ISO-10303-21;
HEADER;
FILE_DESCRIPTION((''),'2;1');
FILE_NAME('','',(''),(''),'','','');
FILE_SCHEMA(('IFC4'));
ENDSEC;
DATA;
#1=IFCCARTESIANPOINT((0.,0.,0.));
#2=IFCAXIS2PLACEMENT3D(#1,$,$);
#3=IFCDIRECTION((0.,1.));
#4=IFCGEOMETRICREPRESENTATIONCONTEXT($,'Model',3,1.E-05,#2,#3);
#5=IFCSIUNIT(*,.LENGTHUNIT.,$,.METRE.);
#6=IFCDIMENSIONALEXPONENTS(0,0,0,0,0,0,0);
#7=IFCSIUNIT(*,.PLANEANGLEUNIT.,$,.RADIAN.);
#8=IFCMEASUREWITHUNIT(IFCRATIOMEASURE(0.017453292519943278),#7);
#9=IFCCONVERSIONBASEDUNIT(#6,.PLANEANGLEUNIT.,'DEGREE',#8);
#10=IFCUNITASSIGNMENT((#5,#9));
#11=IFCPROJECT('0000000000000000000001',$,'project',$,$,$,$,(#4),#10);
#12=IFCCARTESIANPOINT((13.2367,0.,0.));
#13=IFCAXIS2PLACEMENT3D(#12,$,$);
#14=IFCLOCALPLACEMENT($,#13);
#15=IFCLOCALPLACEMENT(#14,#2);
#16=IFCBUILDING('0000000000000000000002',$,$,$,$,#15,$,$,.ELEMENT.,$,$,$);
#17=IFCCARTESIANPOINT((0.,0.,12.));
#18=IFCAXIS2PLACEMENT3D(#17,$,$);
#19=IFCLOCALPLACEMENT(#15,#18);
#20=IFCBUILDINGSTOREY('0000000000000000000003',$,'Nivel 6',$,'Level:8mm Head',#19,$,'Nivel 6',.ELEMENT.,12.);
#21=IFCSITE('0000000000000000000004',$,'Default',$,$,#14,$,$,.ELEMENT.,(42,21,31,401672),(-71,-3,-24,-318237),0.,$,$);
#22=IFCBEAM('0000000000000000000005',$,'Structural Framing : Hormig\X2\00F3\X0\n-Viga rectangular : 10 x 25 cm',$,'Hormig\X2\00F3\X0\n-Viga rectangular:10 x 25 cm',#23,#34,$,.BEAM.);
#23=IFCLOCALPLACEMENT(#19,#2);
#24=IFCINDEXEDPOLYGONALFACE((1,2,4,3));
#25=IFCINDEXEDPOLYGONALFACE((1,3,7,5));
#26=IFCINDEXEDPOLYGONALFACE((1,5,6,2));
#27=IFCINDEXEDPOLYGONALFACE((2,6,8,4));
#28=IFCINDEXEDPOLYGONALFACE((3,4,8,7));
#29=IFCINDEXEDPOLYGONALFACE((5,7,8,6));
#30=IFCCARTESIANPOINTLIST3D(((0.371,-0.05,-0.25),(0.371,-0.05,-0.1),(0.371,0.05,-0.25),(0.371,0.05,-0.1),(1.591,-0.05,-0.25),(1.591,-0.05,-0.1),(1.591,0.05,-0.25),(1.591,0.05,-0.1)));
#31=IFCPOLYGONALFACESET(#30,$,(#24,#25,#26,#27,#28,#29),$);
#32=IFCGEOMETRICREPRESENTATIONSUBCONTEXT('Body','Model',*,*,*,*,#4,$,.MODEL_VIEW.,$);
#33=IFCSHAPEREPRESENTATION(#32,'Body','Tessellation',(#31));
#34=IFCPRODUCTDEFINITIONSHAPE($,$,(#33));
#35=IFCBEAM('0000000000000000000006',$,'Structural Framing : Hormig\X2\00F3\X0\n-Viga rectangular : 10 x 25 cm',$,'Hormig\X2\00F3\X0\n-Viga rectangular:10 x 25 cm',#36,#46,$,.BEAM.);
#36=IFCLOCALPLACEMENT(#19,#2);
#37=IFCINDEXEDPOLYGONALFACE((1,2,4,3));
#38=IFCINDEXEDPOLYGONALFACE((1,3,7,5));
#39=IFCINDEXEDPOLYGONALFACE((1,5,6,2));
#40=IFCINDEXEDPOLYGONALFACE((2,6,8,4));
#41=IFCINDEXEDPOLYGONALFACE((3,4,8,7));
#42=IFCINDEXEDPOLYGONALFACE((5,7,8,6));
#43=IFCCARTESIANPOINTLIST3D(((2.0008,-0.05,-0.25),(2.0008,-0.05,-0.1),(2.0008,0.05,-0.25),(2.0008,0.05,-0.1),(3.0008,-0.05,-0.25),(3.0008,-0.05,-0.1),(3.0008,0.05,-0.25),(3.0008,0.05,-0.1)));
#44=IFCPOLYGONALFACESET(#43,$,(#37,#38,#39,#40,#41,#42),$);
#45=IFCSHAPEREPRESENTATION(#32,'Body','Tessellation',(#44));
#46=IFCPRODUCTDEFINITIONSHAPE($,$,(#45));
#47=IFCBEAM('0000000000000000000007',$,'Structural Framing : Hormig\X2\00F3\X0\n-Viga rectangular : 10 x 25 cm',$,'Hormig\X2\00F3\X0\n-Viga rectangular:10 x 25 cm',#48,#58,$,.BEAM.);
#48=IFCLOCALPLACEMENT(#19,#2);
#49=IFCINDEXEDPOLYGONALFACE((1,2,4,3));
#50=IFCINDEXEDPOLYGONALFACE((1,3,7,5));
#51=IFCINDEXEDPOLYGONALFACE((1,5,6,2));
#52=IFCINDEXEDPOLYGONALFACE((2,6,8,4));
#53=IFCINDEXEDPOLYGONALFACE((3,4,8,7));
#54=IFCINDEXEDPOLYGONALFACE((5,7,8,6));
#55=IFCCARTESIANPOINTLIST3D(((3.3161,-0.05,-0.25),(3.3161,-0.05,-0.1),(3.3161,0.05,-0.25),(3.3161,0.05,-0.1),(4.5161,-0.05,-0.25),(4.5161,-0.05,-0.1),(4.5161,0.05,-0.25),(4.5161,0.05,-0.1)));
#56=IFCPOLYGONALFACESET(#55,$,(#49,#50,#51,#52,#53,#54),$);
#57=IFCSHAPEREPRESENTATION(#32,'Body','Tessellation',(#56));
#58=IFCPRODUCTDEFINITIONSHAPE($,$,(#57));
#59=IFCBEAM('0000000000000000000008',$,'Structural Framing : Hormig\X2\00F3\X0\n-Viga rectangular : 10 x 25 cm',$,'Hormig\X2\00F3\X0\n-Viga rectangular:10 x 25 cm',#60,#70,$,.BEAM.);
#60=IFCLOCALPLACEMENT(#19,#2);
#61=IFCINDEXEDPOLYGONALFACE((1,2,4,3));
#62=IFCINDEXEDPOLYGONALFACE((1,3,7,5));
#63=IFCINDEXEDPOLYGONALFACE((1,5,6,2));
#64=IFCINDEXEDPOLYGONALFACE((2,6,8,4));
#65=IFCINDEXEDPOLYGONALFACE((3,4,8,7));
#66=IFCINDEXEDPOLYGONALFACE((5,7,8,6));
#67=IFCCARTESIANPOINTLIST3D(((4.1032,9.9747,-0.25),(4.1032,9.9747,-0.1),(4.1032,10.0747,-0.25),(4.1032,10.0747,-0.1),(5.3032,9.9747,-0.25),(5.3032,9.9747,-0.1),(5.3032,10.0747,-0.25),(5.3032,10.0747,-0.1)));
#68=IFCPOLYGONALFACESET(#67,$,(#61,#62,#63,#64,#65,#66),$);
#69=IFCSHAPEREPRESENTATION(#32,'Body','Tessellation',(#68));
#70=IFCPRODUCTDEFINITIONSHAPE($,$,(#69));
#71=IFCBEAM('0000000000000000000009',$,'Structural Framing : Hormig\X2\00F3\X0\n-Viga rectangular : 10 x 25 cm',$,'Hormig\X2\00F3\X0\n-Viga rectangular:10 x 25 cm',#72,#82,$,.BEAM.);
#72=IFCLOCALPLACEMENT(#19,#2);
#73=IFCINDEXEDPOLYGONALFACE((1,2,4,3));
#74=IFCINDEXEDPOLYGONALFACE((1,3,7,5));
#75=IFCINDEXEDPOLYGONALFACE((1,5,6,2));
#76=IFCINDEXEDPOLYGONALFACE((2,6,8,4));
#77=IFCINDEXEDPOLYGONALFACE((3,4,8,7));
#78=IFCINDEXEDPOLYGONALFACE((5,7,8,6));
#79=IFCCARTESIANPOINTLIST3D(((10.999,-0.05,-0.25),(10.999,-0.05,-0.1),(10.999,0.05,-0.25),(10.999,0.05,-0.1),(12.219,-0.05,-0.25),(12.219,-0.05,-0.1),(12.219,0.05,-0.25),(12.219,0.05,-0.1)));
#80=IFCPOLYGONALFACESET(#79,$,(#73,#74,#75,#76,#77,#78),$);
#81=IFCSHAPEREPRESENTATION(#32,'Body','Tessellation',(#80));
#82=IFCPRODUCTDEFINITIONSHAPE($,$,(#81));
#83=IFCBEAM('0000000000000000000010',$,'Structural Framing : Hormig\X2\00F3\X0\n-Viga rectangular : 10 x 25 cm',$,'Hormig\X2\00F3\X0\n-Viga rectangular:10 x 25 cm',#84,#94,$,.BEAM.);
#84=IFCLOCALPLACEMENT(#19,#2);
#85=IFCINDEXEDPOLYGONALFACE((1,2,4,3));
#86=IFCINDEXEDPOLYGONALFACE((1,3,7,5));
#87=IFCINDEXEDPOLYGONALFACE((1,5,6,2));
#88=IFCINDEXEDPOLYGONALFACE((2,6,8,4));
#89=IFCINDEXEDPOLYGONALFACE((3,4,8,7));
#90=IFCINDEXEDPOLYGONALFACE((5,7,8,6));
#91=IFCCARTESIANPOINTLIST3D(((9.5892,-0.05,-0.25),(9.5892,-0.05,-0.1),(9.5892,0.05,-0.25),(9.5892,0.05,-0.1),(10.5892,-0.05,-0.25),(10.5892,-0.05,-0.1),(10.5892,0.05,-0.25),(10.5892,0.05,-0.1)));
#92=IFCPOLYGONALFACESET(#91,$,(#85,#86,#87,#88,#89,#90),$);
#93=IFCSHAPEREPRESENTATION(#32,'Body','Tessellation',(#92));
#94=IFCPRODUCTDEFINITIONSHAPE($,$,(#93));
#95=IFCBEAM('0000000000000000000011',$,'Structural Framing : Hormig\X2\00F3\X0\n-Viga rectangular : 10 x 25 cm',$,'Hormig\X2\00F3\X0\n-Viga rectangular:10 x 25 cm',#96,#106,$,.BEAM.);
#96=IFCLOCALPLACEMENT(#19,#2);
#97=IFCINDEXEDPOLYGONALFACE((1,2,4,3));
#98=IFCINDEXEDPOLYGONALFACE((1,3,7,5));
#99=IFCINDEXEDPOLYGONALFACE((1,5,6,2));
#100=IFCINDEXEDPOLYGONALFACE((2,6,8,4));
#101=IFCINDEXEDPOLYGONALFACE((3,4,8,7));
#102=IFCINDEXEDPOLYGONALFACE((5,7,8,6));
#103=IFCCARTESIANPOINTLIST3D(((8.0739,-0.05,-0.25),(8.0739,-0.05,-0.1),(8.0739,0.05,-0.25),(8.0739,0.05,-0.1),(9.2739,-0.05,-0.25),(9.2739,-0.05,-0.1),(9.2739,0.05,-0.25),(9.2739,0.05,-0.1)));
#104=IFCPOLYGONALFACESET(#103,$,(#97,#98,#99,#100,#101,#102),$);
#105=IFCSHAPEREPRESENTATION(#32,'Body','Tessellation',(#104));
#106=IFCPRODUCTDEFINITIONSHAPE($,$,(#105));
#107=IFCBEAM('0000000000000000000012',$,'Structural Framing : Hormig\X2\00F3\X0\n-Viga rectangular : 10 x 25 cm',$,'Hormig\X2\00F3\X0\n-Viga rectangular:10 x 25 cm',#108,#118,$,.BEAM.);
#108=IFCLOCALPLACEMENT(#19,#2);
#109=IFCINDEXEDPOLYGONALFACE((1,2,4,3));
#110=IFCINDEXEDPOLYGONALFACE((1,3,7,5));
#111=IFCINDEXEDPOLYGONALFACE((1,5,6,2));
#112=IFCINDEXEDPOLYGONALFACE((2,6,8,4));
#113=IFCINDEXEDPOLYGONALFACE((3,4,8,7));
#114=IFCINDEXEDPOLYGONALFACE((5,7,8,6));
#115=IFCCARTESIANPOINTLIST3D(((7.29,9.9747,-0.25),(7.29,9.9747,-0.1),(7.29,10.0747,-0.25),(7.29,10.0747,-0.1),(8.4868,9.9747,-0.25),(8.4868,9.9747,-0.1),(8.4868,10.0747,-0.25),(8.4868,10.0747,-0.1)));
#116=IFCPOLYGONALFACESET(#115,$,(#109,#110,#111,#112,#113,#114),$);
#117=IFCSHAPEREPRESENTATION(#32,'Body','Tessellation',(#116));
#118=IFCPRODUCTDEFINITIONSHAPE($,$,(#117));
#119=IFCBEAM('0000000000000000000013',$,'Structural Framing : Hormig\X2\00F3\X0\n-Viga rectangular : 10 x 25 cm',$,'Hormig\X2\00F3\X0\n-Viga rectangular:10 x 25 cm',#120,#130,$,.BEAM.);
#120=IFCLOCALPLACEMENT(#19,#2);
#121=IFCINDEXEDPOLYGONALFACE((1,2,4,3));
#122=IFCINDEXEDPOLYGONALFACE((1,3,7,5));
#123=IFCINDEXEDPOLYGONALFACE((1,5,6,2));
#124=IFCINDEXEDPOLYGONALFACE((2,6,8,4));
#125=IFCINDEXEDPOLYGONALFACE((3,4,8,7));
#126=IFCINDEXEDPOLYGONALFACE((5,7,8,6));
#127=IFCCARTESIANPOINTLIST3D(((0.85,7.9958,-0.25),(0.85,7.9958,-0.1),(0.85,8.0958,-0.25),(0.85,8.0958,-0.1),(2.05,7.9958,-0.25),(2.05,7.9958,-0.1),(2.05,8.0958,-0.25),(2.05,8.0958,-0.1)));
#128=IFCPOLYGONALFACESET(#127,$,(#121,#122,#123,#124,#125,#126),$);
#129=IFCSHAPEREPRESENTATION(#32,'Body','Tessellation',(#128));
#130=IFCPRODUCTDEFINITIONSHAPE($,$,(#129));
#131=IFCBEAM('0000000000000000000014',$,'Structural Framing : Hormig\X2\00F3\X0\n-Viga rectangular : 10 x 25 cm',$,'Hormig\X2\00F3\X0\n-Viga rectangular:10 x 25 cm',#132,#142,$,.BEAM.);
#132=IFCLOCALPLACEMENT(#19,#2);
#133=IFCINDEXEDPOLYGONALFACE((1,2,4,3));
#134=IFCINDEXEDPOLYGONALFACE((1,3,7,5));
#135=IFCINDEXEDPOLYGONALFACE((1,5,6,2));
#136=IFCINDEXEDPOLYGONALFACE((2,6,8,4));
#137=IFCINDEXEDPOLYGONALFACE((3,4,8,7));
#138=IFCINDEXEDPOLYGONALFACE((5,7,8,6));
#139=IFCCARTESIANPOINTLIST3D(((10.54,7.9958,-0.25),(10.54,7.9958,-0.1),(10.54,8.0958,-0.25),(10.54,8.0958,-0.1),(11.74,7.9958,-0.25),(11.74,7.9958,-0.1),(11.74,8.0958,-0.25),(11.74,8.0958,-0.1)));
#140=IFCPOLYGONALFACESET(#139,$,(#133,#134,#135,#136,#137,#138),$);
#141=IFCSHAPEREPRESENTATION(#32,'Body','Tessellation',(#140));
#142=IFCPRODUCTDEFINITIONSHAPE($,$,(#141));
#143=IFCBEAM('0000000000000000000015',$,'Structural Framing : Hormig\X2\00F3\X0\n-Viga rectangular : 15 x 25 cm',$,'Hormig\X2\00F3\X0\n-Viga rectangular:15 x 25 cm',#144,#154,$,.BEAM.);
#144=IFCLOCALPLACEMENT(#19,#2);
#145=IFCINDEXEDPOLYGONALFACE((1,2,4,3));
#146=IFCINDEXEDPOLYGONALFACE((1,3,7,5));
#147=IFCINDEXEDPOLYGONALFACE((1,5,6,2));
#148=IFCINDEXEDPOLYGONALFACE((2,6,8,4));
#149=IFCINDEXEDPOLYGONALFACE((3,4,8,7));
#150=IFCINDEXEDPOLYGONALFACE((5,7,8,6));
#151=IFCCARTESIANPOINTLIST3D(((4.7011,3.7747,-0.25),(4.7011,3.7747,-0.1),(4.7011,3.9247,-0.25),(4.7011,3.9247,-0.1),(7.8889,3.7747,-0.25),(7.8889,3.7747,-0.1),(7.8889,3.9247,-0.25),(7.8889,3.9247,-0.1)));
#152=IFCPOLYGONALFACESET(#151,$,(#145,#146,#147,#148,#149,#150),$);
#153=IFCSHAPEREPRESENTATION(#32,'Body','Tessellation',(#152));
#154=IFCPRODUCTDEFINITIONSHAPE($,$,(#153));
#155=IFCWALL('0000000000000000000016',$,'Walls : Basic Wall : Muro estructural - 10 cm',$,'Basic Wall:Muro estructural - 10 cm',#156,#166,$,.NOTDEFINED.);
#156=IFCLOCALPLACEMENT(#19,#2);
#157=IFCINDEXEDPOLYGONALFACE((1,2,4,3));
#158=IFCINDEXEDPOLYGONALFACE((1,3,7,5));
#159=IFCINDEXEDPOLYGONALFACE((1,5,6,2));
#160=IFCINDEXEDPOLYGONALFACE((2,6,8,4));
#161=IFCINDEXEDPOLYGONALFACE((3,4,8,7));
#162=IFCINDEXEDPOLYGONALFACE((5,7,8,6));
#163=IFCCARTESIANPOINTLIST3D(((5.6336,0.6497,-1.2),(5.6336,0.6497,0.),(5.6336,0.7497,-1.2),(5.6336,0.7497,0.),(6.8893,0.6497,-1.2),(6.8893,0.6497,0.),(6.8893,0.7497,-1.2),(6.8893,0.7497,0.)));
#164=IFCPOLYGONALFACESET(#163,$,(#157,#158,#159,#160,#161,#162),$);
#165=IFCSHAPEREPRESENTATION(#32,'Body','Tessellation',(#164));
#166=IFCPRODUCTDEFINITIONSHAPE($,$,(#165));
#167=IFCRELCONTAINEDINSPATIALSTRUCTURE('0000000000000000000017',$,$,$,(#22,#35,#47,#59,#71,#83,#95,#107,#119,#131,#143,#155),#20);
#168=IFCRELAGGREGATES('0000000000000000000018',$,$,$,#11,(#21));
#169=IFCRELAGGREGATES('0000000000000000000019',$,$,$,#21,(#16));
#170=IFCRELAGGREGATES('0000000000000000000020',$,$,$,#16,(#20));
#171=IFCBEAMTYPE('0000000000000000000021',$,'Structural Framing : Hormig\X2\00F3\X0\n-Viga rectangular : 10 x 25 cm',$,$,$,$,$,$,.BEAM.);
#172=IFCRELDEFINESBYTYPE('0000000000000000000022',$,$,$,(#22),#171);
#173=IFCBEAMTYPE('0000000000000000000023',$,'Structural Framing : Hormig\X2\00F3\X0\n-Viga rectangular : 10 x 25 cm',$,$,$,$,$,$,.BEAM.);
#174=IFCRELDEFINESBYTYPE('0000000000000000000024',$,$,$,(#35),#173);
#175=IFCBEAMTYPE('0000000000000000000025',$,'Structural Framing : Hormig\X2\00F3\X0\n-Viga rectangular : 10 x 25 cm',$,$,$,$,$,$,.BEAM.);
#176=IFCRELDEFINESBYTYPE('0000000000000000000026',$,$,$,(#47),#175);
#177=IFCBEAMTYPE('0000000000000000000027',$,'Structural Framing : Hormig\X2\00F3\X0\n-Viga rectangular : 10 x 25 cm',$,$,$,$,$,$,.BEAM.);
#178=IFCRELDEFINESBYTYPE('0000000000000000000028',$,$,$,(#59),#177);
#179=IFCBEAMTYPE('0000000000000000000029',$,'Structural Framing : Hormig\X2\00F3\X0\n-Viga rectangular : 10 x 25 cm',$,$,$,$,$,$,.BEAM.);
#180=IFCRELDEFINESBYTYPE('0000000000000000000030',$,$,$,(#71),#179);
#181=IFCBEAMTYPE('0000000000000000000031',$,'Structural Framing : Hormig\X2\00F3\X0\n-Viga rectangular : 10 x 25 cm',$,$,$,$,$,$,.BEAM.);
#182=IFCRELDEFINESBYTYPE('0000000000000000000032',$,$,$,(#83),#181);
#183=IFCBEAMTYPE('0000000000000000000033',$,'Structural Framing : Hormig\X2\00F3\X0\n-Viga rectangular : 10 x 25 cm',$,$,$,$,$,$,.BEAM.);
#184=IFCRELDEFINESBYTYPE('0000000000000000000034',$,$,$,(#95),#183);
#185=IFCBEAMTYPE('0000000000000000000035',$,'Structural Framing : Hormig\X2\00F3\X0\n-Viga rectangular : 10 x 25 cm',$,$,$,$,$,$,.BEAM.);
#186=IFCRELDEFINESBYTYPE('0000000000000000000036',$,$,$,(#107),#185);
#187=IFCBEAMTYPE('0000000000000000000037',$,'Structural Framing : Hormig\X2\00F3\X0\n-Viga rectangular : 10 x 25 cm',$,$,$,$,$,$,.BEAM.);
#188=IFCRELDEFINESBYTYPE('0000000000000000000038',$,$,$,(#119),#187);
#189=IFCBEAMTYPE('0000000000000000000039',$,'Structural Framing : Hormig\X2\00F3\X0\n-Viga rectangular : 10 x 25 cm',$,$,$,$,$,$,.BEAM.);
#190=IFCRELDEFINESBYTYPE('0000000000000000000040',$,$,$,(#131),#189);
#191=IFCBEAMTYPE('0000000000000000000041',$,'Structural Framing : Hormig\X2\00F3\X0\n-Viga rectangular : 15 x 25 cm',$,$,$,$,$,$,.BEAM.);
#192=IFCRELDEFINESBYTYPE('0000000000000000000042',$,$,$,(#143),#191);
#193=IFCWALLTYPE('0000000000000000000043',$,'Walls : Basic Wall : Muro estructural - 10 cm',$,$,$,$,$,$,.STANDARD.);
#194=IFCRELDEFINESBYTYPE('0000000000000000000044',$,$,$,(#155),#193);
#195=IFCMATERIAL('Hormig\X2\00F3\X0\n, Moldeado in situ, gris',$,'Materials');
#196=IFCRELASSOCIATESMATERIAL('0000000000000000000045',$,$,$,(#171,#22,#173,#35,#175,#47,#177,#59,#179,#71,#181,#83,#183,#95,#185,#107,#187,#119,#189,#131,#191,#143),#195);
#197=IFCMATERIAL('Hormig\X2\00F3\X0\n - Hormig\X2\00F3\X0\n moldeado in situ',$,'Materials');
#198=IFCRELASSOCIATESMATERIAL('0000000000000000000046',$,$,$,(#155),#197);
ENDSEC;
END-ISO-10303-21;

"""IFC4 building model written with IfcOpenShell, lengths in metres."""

from ifc_helpers import new_model, entity, si_unit, converted_unit, direction, frame, origin, place, context, subcontext, project, spatial, indexed_curve, outline, extrude, source, transform, mapped, material, type_object, type_shapes, element, save


model = new_model("IFC4")

# Units and contexts
model_context = context("Model", 3, precision=1e-05, world=origin(), true_north=direction((0.0, 1.0)))
body_context = subcontext(model_context, "Body", "Model", "MODEL_VIEW")
ifc_project = project(units=[si_unit("LENGTHUNIT", "METRE"), converted_unit("PLANEANGLEUNIT", "DEGREE", entity("IfcRatioMeasure", 0.017453292519943278), si_unit("PLANEANGLEUNIT", "RADIAN"), dimensions=[0, 0, 0, 0, 0, 0, 0])], contexts=[model_context])

# Site, building, storey
site_placement = place(None, frame((13.2367, 0.0, 0.0)))
site = spatial("IfcSite", under=ifc_project, at=site_placement, Name="Default", CompositionType="ELEMENT", RefLatitude=(42, 21, 31, 401672), RefLongitude=(-71, -3, -24, -318237), RefElevation=0.0)
building_placement = place(site_placement, origin())
building = spatial("IfcBuilding", under=site, at=building_placement, CompositionType="ELEMENT")
storey_placement = place(building_placement, frame((0.0, 0.0, 12.0)))
storey = spatial("IfcBuildingStorey", under=building, at=storey_placement, Name="Nivel 6", ObjectType="Level:8mm Head", LongName="Nivel 6", CompositionType="ELEMENT", Elevation=12.0)

# Beams
ifc_material_1 = material(Name="Hormigón, Moldeado in situ, gris", Category="Materials")
beam_type_1 = type_object("IfcBeamType", Name="Structural Framing : Hormigón-Viga rectangular : 10 x 25 cm", PredefinedType="BEAM", material=ifc_material_1)
shared_shape_1 = source(origin(), body_context, "Body", "SweptSolid", [
    extrude(outline(indexed_curve([(-0.075, -0.05), (0.075, -0.05), (0.075, 0.05), (-0.075, 0.05), (-0.075, -0.05)], self_intersect=False)), frame((0.371, 0.0, 11.825), z_axis=(1.0, 0.0, 0.0), x_axis=(0.0, 0.0, -1.0)), (0.0, 0.0, 1.0), 1.22),
])
type_shapes(beam_type_1, [shared_shape_1])
beam_1_placement = place(storey_placement, frame((0.0, 0.0, -12.0)))
element("IfcBeam", 1, at=beam_1_placement, inside=storey, type_object=beam_type_1, material=ifc_material_1, Name="Structural Framing : Hormigón-Viga rectangular : 10 x 25 cm", ObjectType="Hormigón-Viga rectangular:10 x 25 cm", PredefinedType="BEAM", context=body_context, shape_type="MappedRepresentation", body=[
    mapped(shared_shape_1, transform((0.0, 0.0, 0.0), scale=1.0)),
])
beam_type_2 = type_object("IfcBeamType", Name="Structural Framing : Hormigón-Viga rectangular : 10 x 25 cm", PredefinedType="BEAM", material=ifc_material_1)
shared_shape_2 = source(origin(), body_context, "Body", "SweptSolid", [
    extrude(outline(indexed_curve([(-0.075, -0.05), (0.075, -0.05), (0.075, 0.05), (-0.075, 0.05), (-0.075, -0.05)], self_intersect=False)), frame((2.0008, 0.0, 11.825), z_axis=(1.0, 0.0, 0.0), x_axis=(0.0, 0.0, -1.0)), (0.0, 0.0, 1.0), 1.0),
])
type_shapes(beam_type_2, [shared_shape_2])
beam_2_placement = place(storey_placement, frame((0.0, 0.0, -12.0)))
element("IfcBeam", 2, at=beam_2_placement, inside=storey, type_object=beam_type_2, material=ifc_material_1, Name="Structural Framing : Hormigón-Viga rectangular : 10 x 25 cm", ObjectType="Hormigón-Viga rectangular:10 x 25 cm", PredefinedType="BEAM", context=body_context, shape_type="MappedRepresentation", body=[
    mapped(shared_shape_2, transform((0.0, 0.0, 0.0), scale=1.0)),
])
beam_type_3 = type_object("IfcBeamType", Name="Structural Framing : Hormigón-Viga rectangular : 10 x 25 cm", PredefinedType="BEAM", material=ifc_material_1)
shared_shape_3 = source(origin(), body_context, "Body", "SweptSolid", [
    extrude(outline(indexed_curve([(-0.075, -0.05), (0.075, -0.05), (0.075, 0.05), (-0.075, 0.05), (-0.075, -0.05)], self_intersect=False)), frame((3.3161, 0.0, 11.825), z_axis=(1.0, 0.0, 0.0), x_axis=(0.0, 0.0, -1.0)), (0.0, 0.0, 1.0), 1.2),
])
type_shapes(beam_type_3, [shared_shape_3])
beam_3_placement = place(storey_placement, frame((0.0, 0.0, -12.0)))
element("IfcBeam", 3, at=beam_3_placement, inside=storey, type_object=beam_type_3, material=ifc_material_1, Name="Structural Framing : Hormigón-Viga rectangular : 10 x 25 cm", ObjectType="Hormigón-Viga rectangular:10 x 25 cm", PredefinedType="BEAM", context=body_context, shape_type="MappedRepresentation", body=[
    mapped(shared_shape_3, transform((0.0, 0.0, 0.0), scale=1.0)),
])
beam_type_4 = type_object("IfcBeamType", Name="Structural Framing : Hormigón-Viga rectangular : 10 x 25 cm", PredefinedType="BEAM", material=ifc_material_1)
shared_shape_4 = source(origin(), body_context, "Body", "SweptSolid", [
    extrude(outline(indexed_curve([(-0.075, -0.05), (0.075, -0.05), (0.075, 0.05), (-0.075, 0.05), (-0.075, -0.05)], self_intersect=False)), frame((5.3032, 10.0247, 11.825), z_axis=(-1.0, 0.0, 0.0), x_axis=(0.0, 0.0, -1.0)), (0.0, 0.0, 1.0), 1.2),
])
type_shapes(beam_type_4, [shared_shape_4])
beam_4_placement = place(storey_placement, frame((0.0, 0.0, -12.0)))
element("IfcBeam", 4, at=beam_4_placement, inside=storey, type_object=beam_type_4, material=ifc_material_1, Name="Structural Framing : Hormigón-Viga rectangular : 10 x 25 cm", ObjectType="Hormigón-Viga rectangular:10 x 25 cm", PredefinedType="BEAM", context=body_context, shape_type="MappedRepresentation", body=[
    mapped(shared_shape_4, transform((0.0, 0.0, 0.0), scale=1.0)),
])
beam_type_5 = type_object("IfcBeamType", Name="Structural Framing : Hormigón-Viga rectangular : 10 x 25 cm", PredefinedType="BEAM", material=ifc_material_1)
shared_shape_5 = source(origin(), body_context, "Body", "SweptSolid", [
    extrude(outline(indexed_curve([(-0.075, -0.05), (0.075, -0.05), (0.075, 0.05), (-0.075, 0.05), (-0.075, -0.05)], self_intersect=False)), frame((12.219, 0.0, 11.825), z_axis=(-1.0, 0.0, 0.0), x_axis=(0.0, 0.0, -1.0)), (0.0, 0.0, 1.0), 1.22),
])
type_shapes(beam_type_5, [shared_shape_5])
beam_5_placement = place(storey_placement, frame((0.0, 0.0, -12.0)))
element("IfcBeam", 5, at=beam_5_placement, inside=storey, type_object=beam_type_5, material=ifc_material_1, Name="Structural Framing : Hormigón-Viga rectangular : 10 x 25 cm", ObjectType="Hormigón-Viga rectangular:10 x 25 cm", PredefinedType="BEAM", context=body_context, shape_type="MappedRepresentation", body=[
    mapped(shared_shape_5, transform((0.0, 0.0, 0.0), scale=1.0)),
])
beam_type_6 = type_object("IfcBeamType", Name="Structural Framing : Hormigón-Viga rectangular : 10 x 25 cm", PredefinedType="BEAM", material=ifc_material_1)
shared_shape_6 = source(origin(), body_context, "Body", "SweptSolid", [
    extrude(outline(indexed_curve([(-0.075, -0.05), (0.075, -0.05), (0.075, 0.05), (-0.075, 0.05), (-0.075, -0.05)], self_intersect=False)), frame((10.5892, 0.0, 11.825), z_axis=(-1.0, 0.0, 0.0), x_axis=(0.0, 0.0, -1.0)), (0.0, 0.0, 1.0), 1.0),
])
type_shapes(beam_type_6, [shared_shape_6])
beam_6_placement = place(storey_placement, frame((0.0, 0.0, -12.0)))
element("IfcBeam", 6, at=beam_6_placement, inside=storey, type_object=beam_type_6, material=ifc_material_1, Name="Structural Framing : Hormigón-Viga rectangular : 10 x 25 cm", ObjectType="Hormigón-Viga rectangular:10 x 25 cm", PredefinedType="BEAM", context=body_context, shape_type="MappedRepresentation", body=[
    mapped(shared_shape_6, transform((0.0, 0.0, 0.0), scale=1.0)),
])
beam_type_7 = type_object("IfcBeamType", Name="Structural Framing : Hormigón-Viga rectangular : 10 x 25 cm", PredefinedType="BEAM", material=ifc_material_1)
shared_shape_7 = source(origin(), body_context, "Body", "SweptSolid", [
    extrude(outline(indexed_curve([(-0.075, -0.05), (0.075, -0.05), (0.075, 0.05), (-0.075, 0.05), (-0.075, -0.05)], self_intersect=False)), frame((9.2739, 0.0, 11.825), z_axis=(-1.0, 0.0, 0.0), x_axis=(0.0, 0.0, -1.0)), (0.0, 0.0, 1.0), 1.2),
])
type_shapes(beam_type_7, [shared_shape_7])
beam_7_placement = place(storey_placement, frame((0.0, 0.0, -12.0)))
element("IfcBeam", 7, at=beam_7_placement, inside=storey, type_object=beam_type_7, material=ifc_material_1, Name="Structural Framing : Hormigón-Viga rectangular : 10 x 25 cm", ObjectType="Hormigón-Viga rectangular:10 x 25 cm", PredefinedType="BEAM", context=body_context, shape_type="MappedRepresentation", body=[
    mapped(shared_shape_7, transform((0.0, 0.0, 0.0), scale=1.0)),
])
beam_type_8 = type_object("IfcBeamType", Name="Structural Framing : Hormigón-Viga rectangular : 10 x 25 cm", PredefinedType="BEAM", material=ifc_material_1)
shared_shape_8 = source(origin(), body_context, "Body", "SweptSolid", [
    extrude(outline(indexed_curve([(-0.075, -0.05), (0.075, -0.05), (0.075, 0.05), (-0.075, 0.05), (-0.075, -0.05)], self_intersect=False)), frame((7.29, 10.0247, 11.825), z_axis=(1.0, 0.0, 0.0), x_axis=(0.0, 0.0, -1.0)), (0.0, 0.0, 1.0), 1.1968),
])
type_shapes(beam_type_8, [shared_shape_8])
beam_8_placement = place(storey_placement, frame((0.0, 0.0, -12.0)))
element("IfcBeam", 8, at=beam_8_placement, inside=storey, type_object=beam_type_8, material=ifc_material_1, Name="Structural Framing : Hormigón-Viga rectangular : 10 x 25 cm", ObjectType="Hormigón-Viga rectangular:10 x 25 cm", PredefinedType="BEAM", context=body_context, shape_type="MappedRepresentation", body=[
    mapped(shared_shape_8, transform((0.0, 0.0, 0.0), scale=1.0)),
])
beam_type_9 = type_object("IfcBeamType", Name="Structural Framing : Hormigón-Viga rectangular : 10 x 25 cm", PredefinedType="BEAM", material=ifc_material_1)
shared_shape_9 = source(origin(), body_context, "Body", "SweptSolid", [
    extrude(outline(indexed_curve([(-0.075, -0.05), (0.075, -0.05), (0.075, 0.05), (-0.075, 0.05), (-0.075, -0.05)], self_intersect=False)), frame((2.05, 8.0458, 11.825), z_axis=(-1.0, 0.0, 0.0), x_axis=(0.0, 0.0, -1.0)), (0.0, 0.0, 1.0), 1.2),
])
type_shapes(beam_type_9, [shared_shape_9])
beam_9_placement = place(storey_placement, frame((0.0, 0.0, -12.0)))
element("IfcBeam", 9, at=beam_9_placement, inside=storey, type_object=beam_type_9, material=ifc_material_1, Name="Structural Framing : Hormigón-Viga rectangular : 10 x 25 cm", ObjectType="Hormigón-Viga rectangular:10 x 25 cm", PredefinedType="BEAM", context=body_context, shape_type="MappedRepresentation", body=[
    mapped(shared_shape_9, transform((0.0, 0.0, 0.0), scale=1.0)),
])
beam_type_10 = type_object("IfcBeamType", Name="Structural Framing : Hormigón-Viga rectangular : 10 x 25 cm", PredefinedType="BEAM", material=ifc_material_1)
shared_shape_10 = source(origin(), body_context, "Body", "SweptSolid", [
    extrude(outline(indexed_curve([(-0.075, -0.05), (0.075, -0.05), (0.075, 0.05), (-0.075, 0.05), (-0.075, -0.05)], self_intersect=False)), frame((10.54, 8.0458, 11.825), z_axis=(1.0, 0.0, 0.0), x_axis=(0.0, 0.0, -1.0)), (0.0, 0.0, 1.0), 1.2),
])
type_shapes(beam_type_10, [shared_shape_10])
beam_10_placement = place(storey_placement, frame((0.0, 0.0, -12.0)))
element("IfcBeam", 10, at=beam_10_placement, inside=storey, type_object=beam_type_10, material=ifc_material_1, Name="Structural Framing : Hormigón-Viga rectangular : 10 x 25 cm", ObjectType="Hormigón-Viga rectangular:10 x 25 cm", PredefinedType="BEAM", context=body_context, shape_type="MappedRepresentation", body=[
    mapped(shared_shape_10, transform((0.0, 0.0, 0.0), scale=1.0)),
])
beam_type_11 = type_object("IfcBeamType", Name="Structural Framing : Hormigón-Viga rectangular : 15 x 25 cm", PredefinedType="BEAM", material=ifc_material_1)
shared_shape_11 = source(origin(), body_context, "Body", "SweptSolid", [
    extrude(outline(indexed_curve([(-0.075, -0.075), (0.075, -0.075), (0.075, 0.075), (-0.075, 0.075), (-0.075, -0.075)], self_intersect=False)), frame((4.7011, 3.8497, 11.825), z_axis=(1.0, 0.0, 0.0), x_axis=(0.0, 0.0, -1.0)), (0.0, 0.0, 1.0), 3.1878),
])
type_shapes(beam_type_11, [shared_shape_11])
beam_11_placement = place(storey_placement, frame((0.0, 0.0, -12.0)))
element("IfcBeam", 11, at=beam_11_placement, inside=storey, type_object=beam_type_11, material=ifc_material_1, Name="Structural Framing : Hormigón-Viga rectangular : 15 x 25 cm", ObjectType="Hormigón-Viga rectangular:15 x 25 cm", PredefinedType="BEAM", context=body_context, shape_type="MappedRepresentation", body=[
    mapped(shared_shape_11, transform((0.0, 0.0, 0.0), scale=1.0)),
])

# Shared definitions
ifc_material_2 = material(Name="Hormigón - Hormigón moldeado in situ", Category="Materials")

# Wall
wall_type = type_object("IfcWallType", Name="Walls : Basic Wall : Muro estructural - 10 cm", PredefinedType="STANDARD")
wall_placement = place(storey_placement, frame((5.6336, 0.6997, -1.2)))
element("IfcWall", 12, at=wall_placement, inside=storey, type_object=wall_type, material=ifc_material_2, Name="Walls : Basic Wall : Muro estructural - 10 cm", ObjectType="Basic Wall:Muro estructural - 10 cm", PredefinedType="NOTDEFINED", context=body_context, shape_type="SweptSolid", body=[
    extrude(outline(indexed_curve([(1.2557, 0.05), (0.0, 0.05), (0.0, -0.05), (1.2557, -0.05), (1.2557, 0.05)], self_intersect=False)), origin(), (0.0, 0.0, 1.0), 1.2),
])

save(model, "model.ifc")
